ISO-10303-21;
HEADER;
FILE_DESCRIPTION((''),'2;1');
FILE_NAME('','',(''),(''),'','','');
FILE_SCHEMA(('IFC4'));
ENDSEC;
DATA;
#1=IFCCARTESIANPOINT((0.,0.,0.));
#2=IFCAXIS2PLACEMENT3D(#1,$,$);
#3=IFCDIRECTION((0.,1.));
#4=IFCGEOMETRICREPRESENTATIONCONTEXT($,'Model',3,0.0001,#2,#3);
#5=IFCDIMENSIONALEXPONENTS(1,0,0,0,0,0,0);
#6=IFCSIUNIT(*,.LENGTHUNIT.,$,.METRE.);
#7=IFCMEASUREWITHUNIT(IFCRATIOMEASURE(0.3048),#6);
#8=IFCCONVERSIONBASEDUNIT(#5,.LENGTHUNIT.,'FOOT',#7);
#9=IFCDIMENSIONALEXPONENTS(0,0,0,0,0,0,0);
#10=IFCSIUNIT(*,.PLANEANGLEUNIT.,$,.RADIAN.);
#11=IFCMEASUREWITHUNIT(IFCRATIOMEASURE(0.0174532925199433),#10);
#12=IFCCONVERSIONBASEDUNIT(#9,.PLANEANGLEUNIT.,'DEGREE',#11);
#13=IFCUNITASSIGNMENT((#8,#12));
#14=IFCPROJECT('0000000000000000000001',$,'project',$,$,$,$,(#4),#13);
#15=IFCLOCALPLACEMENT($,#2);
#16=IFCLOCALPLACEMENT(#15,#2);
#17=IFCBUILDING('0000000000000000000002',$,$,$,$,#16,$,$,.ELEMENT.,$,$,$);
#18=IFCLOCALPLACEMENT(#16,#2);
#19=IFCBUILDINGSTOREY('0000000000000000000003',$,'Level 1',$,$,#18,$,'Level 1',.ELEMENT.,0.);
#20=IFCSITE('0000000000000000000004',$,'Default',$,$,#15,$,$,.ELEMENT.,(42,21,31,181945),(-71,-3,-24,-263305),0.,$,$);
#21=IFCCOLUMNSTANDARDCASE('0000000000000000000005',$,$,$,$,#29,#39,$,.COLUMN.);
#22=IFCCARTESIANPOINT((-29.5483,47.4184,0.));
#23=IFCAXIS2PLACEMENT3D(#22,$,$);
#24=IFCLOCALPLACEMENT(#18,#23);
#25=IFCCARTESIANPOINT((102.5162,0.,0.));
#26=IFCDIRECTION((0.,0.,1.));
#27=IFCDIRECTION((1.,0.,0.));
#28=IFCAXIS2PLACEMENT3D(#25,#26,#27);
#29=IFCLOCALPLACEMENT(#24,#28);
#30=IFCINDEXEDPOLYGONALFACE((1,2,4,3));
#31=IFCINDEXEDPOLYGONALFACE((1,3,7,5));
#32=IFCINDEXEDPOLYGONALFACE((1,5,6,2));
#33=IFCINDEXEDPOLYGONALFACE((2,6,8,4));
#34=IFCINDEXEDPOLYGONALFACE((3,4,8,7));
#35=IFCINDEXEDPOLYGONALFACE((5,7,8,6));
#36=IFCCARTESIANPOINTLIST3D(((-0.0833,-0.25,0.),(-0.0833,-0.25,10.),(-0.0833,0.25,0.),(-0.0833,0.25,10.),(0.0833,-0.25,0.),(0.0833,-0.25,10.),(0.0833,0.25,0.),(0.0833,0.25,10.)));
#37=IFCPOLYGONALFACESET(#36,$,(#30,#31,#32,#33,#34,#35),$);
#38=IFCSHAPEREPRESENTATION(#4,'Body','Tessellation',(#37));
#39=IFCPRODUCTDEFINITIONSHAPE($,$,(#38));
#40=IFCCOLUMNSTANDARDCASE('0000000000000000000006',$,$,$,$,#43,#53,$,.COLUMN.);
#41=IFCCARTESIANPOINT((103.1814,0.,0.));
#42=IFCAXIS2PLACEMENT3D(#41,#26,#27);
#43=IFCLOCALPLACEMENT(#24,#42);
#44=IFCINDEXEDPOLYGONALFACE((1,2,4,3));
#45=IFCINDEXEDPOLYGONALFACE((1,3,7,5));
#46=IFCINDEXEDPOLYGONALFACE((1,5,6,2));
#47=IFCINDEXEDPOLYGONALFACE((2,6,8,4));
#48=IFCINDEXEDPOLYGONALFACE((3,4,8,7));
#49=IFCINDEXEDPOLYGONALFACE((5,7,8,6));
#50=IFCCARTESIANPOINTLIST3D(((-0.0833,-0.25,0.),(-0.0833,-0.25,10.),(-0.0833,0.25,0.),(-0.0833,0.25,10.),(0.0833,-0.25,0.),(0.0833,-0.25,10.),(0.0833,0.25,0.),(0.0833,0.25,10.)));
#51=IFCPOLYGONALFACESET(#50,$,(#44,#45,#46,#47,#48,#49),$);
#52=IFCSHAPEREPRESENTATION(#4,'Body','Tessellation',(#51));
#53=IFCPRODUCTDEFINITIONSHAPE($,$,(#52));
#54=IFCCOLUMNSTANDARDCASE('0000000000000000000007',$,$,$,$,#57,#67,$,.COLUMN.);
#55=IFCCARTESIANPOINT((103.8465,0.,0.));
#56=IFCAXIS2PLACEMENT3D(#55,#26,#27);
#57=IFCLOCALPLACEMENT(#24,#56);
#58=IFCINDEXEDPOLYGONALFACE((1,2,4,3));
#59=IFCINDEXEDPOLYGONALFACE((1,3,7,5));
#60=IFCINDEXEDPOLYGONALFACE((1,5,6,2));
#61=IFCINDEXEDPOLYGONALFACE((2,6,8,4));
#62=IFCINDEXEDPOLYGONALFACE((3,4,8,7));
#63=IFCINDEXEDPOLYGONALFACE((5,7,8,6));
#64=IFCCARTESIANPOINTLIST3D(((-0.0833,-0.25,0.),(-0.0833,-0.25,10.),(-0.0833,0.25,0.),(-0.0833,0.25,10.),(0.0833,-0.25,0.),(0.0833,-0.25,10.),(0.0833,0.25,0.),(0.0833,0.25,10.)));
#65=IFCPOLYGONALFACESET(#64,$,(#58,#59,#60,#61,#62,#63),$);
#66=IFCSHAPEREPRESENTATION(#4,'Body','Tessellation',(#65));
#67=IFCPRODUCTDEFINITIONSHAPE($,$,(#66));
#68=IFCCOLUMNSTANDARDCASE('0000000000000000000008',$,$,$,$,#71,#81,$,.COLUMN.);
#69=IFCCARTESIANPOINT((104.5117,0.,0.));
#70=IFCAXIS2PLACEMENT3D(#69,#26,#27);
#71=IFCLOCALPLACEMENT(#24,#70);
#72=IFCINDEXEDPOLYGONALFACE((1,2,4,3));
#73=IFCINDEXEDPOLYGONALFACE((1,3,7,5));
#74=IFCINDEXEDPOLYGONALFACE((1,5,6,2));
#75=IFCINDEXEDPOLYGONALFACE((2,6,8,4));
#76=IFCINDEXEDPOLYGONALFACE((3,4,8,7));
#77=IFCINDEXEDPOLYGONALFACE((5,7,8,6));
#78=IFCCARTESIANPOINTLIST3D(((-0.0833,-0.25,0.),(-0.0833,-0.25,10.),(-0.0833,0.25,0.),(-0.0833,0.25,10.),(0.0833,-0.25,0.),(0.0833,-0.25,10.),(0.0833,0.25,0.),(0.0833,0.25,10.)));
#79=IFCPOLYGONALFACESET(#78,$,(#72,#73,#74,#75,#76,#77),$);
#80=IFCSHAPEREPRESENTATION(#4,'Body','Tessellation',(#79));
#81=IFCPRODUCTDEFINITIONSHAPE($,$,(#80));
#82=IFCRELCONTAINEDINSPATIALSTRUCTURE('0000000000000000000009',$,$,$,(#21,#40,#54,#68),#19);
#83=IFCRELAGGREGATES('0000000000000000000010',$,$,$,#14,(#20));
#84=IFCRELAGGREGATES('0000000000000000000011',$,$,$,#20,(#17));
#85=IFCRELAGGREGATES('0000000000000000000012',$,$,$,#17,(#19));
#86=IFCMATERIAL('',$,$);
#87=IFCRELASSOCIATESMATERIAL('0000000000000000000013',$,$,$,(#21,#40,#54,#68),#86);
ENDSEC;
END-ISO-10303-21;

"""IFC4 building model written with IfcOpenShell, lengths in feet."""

from ifc_helpers import new_model, entity, si_unit, converted_unit, direction, frame, origin, place, context, project, spatial, rectangle, extrude, material, element, save


model = new_model("IFC4")

# Units and contexts
model_context = context("Model", 3, precision=0.0001, world=origin(), true_north=direction((0.0, 1.0)))
ifc_project = project(units=[converted_unit("LENGTHUNIT", "FOOT", entity("IfcRatioMeasure", 0.3048), si_unit("LENGTHUNIT", "METRE"), dimensions=[1, 0, 0, 0, 0, 0, 0]), converted_unit("PLANEANGLEUNIT", "DEGREE", entity("IfcRatioMeasure", 0.0174532925199433), si_unit("PLANEANGLEUNIT", "RADIAN"), dimensions=[0, 0, 0, 0, 0, 0, 0])], contexts=[model_context])

# Site, building, storey
site_placement = place(None, origin())
site = spatial("IfcSite", under=ifc_project, at=site_placement, Name="Default", CompositionType="ELEMENT", RefLatitude=(42, 21, 31, 181945), RefLongitude=(-71, -3, -24, -263305), RefElevation=0.0)
building_placement = place(site_placement, origin())
building = spatial("IfcBuilding", under=site, at=building_placement, CompositionType="ELEMENT")
storey_placement = place(building_placement, origin())
storey = spatial("IfcBuildingStorey", under=building, at=storey_placement, Name="Level 1", LongName="Level 1", CompositionType="ELEMENT", Elevation=0.0)

# Columns
ifc_material_1 = material(Name="")
placement = place(storey_placement, frame((-29.5483, 47.4184, 0.0)))
for number, where, z_axis, x_axis in (
    (1, (102.5162, 0.0, 0.0), (0.0, 0.0, 1.0), (1.0, 0.0, 0.0)),
    (2, (103.1814, 0.0, 0.0), (0.0, 0.0, 1.0), (1.0, 0.0, 0.0)),
    (3, (103.8465, 0.0, 0.0), (0.0, 0.0, 1.0), (1.0, 0.0, 0.0)),
    (4, (104.5117, 0.0, 0.0), (0.0, 0.0, 1.0), (1.0, 0.0, 0.0)),
):
    element("IfcColumnStandardCase", number, at=place(placement, frame(where, z_axis=z_axis, x_axis=x_axis)), inside=storey, material=ifc_material_1, PredefinedType="COLUMN", context=model_context, shape_type="SweptSolid", body=[
        extrude(rectangle(XDim=0.1667, YDim=0.5), origin(), (0.0, 0.0, 1.0), 10.0),
    ])

save(model, "model.ifc")
